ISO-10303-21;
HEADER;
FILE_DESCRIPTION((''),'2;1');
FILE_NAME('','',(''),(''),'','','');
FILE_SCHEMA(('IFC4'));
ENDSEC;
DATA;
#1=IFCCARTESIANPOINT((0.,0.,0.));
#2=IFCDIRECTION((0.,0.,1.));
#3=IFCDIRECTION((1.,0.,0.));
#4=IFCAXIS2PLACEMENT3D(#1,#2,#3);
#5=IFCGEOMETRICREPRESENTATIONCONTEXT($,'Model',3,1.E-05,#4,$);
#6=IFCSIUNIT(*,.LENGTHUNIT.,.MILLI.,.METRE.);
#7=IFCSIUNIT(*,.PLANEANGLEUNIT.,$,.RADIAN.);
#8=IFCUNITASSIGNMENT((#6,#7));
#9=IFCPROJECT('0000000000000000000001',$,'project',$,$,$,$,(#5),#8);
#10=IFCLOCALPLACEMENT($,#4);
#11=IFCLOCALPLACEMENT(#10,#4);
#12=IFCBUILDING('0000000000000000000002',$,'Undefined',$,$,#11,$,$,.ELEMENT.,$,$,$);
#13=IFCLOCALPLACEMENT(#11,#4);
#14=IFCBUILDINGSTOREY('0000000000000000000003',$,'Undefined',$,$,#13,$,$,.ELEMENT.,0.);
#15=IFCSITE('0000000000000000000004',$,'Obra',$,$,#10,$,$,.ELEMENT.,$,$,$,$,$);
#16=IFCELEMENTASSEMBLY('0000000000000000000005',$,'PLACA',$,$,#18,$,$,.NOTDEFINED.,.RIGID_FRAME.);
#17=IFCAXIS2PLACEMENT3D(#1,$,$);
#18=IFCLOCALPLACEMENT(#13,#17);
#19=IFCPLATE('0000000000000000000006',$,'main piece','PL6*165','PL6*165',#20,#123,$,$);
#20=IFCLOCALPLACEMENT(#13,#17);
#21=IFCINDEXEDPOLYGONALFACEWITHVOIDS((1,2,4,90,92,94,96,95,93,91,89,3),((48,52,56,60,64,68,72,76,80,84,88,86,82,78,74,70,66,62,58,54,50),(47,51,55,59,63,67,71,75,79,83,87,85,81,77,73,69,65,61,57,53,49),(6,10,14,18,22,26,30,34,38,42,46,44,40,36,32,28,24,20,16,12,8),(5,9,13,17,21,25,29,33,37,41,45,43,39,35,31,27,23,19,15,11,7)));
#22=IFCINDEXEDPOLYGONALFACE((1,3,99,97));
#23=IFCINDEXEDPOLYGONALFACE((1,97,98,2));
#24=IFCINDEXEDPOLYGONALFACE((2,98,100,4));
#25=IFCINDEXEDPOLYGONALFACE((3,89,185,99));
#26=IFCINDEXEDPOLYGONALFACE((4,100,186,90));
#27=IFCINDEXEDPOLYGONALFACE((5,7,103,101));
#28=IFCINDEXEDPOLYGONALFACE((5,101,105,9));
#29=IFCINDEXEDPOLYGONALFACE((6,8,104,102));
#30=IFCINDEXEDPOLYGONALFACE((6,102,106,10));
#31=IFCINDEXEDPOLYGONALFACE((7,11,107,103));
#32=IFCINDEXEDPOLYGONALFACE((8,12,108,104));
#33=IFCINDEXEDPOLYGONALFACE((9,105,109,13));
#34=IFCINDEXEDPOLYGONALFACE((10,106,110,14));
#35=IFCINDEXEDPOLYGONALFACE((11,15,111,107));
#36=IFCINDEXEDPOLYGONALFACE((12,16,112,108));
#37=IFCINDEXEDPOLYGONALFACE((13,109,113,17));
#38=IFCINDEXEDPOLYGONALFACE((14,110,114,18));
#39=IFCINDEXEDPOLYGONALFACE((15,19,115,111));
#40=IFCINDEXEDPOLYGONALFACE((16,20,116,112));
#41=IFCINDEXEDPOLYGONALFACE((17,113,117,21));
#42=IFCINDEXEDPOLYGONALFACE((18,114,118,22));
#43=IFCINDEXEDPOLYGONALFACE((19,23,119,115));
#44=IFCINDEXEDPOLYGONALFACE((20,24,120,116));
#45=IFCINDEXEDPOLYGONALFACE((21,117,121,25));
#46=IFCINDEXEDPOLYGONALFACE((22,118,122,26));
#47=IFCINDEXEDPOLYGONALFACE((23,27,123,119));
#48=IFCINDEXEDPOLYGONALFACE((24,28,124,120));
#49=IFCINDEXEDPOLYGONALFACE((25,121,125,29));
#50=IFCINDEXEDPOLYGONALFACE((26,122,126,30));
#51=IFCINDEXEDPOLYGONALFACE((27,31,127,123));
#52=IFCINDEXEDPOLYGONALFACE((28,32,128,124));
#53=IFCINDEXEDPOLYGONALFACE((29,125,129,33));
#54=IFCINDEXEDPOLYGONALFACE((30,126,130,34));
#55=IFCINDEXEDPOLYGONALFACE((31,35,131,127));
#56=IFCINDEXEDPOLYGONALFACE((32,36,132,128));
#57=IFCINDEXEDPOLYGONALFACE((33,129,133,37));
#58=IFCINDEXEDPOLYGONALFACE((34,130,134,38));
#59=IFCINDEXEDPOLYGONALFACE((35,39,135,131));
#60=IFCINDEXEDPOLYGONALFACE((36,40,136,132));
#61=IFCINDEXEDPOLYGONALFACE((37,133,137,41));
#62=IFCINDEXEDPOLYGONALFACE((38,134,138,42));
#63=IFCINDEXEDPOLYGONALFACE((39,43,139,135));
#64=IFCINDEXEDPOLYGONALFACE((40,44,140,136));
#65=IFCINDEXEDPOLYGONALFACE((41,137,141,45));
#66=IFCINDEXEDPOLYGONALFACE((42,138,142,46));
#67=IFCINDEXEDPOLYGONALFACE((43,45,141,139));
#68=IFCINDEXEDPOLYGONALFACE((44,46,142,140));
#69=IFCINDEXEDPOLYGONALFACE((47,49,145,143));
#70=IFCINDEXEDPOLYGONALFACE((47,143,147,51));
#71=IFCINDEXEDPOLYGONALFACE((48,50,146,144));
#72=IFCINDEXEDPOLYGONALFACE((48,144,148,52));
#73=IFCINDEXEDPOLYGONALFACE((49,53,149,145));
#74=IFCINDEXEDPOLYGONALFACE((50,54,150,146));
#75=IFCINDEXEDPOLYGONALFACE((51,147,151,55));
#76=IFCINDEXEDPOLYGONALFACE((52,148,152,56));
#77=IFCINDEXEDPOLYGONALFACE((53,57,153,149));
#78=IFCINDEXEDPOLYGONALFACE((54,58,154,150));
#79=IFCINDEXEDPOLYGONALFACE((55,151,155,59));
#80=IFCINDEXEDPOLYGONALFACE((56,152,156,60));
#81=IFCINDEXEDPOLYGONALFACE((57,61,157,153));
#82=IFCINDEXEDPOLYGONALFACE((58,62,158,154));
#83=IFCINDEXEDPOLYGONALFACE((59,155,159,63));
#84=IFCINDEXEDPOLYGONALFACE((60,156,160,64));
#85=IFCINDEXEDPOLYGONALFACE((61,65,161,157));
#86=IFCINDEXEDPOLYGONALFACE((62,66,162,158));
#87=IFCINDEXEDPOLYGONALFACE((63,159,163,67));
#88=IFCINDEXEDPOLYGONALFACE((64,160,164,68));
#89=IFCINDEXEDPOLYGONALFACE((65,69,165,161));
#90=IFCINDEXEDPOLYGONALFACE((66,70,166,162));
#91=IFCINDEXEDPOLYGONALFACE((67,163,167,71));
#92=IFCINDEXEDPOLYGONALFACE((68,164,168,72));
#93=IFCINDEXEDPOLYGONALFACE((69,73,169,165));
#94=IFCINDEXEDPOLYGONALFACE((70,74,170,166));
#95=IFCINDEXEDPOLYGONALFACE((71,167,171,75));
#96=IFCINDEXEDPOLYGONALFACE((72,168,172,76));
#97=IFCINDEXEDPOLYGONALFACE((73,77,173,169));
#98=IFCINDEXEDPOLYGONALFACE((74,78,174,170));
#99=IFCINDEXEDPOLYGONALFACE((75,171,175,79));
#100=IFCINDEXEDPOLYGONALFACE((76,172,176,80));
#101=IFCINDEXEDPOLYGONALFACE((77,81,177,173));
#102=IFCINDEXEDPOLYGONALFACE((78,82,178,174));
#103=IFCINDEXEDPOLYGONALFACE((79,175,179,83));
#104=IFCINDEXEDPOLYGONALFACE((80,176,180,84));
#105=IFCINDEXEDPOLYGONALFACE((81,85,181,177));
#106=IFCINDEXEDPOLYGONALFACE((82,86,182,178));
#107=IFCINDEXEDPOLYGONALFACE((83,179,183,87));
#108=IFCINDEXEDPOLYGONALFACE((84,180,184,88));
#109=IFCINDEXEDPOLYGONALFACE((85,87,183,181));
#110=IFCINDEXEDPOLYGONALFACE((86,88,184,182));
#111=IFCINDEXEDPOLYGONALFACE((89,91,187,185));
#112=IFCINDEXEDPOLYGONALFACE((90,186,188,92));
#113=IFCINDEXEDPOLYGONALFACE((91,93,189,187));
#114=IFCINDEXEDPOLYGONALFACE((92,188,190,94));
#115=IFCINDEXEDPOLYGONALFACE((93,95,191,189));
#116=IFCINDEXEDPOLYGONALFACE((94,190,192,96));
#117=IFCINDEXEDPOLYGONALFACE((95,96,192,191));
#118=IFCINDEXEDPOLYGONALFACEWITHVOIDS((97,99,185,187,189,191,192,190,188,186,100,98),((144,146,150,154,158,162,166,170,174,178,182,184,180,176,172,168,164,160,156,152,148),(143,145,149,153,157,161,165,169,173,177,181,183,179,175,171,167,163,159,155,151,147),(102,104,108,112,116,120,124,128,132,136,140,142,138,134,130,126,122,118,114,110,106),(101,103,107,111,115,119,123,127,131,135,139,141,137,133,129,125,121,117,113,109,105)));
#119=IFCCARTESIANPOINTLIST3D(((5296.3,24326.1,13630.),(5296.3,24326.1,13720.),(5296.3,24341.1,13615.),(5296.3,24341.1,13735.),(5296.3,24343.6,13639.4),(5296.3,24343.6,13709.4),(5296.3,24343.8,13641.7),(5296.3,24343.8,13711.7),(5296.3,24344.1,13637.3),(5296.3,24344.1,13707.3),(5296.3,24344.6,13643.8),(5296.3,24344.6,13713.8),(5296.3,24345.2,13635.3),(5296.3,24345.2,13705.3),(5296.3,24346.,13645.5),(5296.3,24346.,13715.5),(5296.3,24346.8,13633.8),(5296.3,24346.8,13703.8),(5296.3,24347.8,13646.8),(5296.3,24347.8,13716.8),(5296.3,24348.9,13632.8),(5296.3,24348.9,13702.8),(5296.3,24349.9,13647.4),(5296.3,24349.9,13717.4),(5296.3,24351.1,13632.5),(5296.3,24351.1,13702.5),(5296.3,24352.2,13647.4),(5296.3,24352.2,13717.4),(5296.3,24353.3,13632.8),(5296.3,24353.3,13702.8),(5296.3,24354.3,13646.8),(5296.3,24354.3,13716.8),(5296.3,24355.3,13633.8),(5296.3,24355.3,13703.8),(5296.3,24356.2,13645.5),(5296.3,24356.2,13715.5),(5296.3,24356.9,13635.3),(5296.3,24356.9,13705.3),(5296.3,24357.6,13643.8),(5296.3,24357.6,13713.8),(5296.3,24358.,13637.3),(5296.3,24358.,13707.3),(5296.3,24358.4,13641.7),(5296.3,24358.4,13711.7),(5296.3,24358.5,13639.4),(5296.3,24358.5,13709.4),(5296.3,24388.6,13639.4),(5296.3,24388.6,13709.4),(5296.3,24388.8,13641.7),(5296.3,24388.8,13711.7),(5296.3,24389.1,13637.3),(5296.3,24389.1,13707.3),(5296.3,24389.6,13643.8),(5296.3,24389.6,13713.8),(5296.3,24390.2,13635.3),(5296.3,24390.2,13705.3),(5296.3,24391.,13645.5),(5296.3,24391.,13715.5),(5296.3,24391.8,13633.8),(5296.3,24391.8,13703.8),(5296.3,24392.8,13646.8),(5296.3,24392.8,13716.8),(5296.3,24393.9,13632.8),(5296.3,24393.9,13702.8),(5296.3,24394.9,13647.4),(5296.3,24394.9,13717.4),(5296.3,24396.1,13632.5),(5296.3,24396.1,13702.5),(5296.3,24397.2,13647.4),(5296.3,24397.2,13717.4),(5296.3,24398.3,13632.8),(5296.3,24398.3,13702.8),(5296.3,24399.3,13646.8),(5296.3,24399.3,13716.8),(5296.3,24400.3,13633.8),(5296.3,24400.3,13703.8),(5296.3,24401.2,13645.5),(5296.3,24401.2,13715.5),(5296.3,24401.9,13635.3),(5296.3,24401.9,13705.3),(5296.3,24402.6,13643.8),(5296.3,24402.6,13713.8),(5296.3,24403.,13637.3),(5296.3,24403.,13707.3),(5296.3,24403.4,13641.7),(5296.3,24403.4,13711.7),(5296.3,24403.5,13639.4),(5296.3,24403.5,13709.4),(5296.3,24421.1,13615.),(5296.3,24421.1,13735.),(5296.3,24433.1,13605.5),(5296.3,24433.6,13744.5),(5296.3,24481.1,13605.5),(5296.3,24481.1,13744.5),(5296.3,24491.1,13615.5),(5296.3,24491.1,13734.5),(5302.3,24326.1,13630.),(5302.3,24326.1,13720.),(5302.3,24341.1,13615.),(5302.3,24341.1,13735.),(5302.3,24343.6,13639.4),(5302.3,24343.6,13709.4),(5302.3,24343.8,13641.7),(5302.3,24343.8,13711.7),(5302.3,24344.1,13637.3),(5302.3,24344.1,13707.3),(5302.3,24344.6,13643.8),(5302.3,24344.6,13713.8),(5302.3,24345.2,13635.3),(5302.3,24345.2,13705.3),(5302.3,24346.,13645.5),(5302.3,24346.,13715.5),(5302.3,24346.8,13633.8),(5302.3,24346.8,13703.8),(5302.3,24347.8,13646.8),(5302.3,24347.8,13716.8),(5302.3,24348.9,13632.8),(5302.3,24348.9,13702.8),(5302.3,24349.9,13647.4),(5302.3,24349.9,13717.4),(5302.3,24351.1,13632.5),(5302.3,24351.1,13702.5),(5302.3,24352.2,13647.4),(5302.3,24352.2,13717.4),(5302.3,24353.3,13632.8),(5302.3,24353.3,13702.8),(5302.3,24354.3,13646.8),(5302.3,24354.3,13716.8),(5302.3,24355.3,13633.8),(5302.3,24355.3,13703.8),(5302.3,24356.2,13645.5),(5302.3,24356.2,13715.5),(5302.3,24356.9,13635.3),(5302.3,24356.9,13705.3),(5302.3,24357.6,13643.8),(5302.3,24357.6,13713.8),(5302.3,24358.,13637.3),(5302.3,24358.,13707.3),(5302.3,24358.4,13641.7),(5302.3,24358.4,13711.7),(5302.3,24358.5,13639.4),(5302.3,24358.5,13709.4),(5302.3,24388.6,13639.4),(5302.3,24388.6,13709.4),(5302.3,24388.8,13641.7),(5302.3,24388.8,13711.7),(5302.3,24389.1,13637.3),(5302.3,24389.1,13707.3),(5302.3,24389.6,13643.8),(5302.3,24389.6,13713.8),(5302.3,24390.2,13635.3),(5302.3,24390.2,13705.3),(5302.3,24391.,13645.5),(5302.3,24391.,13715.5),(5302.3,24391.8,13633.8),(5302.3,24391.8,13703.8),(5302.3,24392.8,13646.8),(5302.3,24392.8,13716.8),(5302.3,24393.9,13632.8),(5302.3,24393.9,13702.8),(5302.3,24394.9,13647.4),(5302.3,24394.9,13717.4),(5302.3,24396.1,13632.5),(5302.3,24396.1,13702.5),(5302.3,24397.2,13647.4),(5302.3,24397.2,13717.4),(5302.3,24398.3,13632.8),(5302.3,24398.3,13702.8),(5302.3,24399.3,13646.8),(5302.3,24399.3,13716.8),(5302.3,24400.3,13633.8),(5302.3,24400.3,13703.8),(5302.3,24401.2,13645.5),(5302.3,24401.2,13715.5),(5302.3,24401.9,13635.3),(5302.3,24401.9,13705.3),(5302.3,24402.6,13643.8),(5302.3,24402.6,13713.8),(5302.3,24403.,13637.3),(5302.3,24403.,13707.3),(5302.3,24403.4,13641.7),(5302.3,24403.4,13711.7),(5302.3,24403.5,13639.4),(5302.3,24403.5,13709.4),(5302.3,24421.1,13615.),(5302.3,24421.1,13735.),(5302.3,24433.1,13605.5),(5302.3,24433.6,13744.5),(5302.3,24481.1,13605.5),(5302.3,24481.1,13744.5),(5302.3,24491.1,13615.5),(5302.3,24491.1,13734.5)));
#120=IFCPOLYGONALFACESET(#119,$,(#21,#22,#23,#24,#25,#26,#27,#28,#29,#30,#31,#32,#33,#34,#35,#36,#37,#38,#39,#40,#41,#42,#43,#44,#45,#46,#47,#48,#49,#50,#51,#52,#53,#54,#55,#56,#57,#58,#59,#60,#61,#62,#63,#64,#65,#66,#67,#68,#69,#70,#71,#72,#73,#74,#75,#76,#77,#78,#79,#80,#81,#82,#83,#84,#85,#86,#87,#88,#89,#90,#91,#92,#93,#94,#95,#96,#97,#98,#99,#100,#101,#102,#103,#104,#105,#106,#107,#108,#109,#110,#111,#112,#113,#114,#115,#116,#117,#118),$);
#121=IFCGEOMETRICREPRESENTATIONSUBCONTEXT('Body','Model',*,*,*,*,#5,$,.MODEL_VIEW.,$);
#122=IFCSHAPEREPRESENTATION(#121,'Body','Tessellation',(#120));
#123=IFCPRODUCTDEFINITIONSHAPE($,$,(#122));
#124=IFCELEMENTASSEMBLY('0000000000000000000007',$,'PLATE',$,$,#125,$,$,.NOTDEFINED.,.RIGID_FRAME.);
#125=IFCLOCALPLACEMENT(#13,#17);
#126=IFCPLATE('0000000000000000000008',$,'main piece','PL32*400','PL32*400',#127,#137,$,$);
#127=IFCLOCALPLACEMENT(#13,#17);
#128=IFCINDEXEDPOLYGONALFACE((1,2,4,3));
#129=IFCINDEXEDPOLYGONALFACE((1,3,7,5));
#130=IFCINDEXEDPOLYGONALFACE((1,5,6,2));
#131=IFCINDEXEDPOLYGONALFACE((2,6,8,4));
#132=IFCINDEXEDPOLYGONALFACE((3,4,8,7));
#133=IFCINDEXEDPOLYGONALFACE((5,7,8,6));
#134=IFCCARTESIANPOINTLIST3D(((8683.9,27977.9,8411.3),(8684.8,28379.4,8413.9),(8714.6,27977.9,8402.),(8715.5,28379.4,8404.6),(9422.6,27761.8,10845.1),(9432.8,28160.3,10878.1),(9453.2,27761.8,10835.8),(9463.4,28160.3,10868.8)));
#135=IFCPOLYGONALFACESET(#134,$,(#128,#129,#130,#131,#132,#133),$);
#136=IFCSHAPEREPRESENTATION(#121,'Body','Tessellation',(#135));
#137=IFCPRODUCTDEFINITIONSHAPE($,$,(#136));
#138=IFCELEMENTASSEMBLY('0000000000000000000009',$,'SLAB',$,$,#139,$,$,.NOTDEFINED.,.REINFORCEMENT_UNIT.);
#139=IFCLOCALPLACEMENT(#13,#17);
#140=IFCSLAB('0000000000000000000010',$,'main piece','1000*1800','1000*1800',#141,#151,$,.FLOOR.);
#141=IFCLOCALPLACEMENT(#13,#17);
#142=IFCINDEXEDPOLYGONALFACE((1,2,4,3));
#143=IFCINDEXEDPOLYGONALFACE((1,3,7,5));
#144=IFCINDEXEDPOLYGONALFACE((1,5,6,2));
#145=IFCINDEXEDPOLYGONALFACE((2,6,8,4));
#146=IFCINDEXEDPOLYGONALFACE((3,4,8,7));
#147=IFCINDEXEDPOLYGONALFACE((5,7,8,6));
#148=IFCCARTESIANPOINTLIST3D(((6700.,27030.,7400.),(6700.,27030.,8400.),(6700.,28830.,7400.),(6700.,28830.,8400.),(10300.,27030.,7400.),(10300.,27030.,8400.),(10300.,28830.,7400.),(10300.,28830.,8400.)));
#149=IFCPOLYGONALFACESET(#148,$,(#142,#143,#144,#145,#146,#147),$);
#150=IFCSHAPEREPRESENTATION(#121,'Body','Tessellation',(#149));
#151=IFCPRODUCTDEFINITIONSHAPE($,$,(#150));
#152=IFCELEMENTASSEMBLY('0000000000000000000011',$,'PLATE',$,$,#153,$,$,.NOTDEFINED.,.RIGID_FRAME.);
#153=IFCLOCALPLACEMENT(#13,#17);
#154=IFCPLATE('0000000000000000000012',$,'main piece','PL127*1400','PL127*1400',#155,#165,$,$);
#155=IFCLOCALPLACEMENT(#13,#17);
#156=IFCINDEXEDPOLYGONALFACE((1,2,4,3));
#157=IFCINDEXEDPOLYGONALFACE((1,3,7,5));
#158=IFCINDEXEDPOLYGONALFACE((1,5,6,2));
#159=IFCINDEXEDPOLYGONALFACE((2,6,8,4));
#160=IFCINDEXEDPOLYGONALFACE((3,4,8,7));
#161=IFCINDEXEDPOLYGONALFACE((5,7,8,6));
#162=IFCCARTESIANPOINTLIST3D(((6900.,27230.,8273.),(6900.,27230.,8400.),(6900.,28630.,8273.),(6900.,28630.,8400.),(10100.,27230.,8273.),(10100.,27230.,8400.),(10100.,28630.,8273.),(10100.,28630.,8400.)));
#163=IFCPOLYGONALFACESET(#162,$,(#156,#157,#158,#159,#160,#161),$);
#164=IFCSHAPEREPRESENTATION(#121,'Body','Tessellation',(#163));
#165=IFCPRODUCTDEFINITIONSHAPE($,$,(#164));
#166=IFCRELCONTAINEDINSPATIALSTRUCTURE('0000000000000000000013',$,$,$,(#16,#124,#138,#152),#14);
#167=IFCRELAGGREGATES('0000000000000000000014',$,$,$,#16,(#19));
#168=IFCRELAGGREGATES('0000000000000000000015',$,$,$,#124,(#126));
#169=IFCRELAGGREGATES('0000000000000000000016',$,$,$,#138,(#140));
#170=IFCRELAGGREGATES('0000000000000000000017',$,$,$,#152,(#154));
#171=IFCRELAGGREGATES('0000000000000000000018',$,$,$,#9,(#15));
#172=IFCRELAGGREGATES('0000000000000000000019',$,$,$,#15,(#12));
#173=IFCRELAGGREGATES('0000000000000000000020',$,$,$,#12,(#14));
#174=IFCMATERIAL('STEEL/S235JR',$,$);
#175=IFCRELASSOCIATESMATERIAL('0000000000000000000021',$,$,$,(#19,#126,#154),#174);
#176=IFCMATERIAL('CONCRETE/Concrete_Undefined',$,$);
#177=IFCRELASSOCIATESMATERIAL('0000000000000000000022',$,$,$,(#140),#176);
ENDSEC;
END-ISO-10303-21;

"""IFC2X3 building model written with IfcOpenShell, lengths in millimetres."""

from ifc_helpers import new_model, si_unit, frame, origin_with_axes, origin_2d_with_axis, place, context, subcontext, project, spatial, polyline, circle, outline, extrude, source, transform, mapped, material, element, aggregate, save


model = new_model("IFC2X3")

# Units and contexts
model_context = context("Model", 3, precision=1e-05, world=origin_with_axes())
body_context = subcontext(model_context, "Body", "Model", "MODEL_VIEW")
ifc_project = project(units=[si_unit("LENGTHUNIT", "METRE", prefix="MILLI"), si_unit("PLANEANGLEUNIT", "RADIAN")], contexts=[model_context])

# Site, building, storey
site_placement = place(None, origin_with_axes())
site = spatial("IfcSite", under=ifc_project, at=site_placement, Name="Obra", CompositionType="ELEMENT")
building_placement = place(site_placement, origin_with_axes())
building = spatial("IfcBuilding", under=site, at=building_placement, Name="Undefined", CompositionType="ELEMENT")
storey_placement = place(building_placement, origin_with_axes())
storey = spatial("IfcBuildingStorey", under=building, at=storey_placement, Name="Undefined", CompositionType="ELEMENT", Elevation=0.0)

# Shared definitions
ifc_material_1 = material(Name="STEEL/S235JR")

# Element assembly, plate, opening
assembly_1_placement = place(storey_placement, origin_with_axes())
assembly_1 = element("IfcElementAssembly", 1, at=assembly_1_placement, inside=storey, Name="PLACA", AssemblyPlace="NOTDEFINED", PredefinedType="RIGID_FRAME")
plate_1_placement = place(assembly_1_placement, frame((5299.3, 24491.1, 13615.5), z_axis=(-1.0, 0.0, 0.0), x_axis=(0.000001, -0.707107, -0.707107)))
plate_1 = element("IfcPlate", 2, at=plate_1_placement, material=ifc_material_1, Name="main piece", Description="PL6*165", ObjectType="PL6*165", context=body_context, shape_type="SweptSolid", body=[
    extrude(outline(polyline([(0.0, 0.0), (14.1, 0.0), (48.1, 33.9), (49.9, 49.1), (106.4, 105.7), (106.4, 126.9), (42.8, 190.6), (21.6, 190.6), (-35.0, 134.0), (-50.6, 131.9), (-84.1, 98.3), (-84.1, 84.1), (0.0, 0.0)])), frame((0.0, 0.0, -3.0), z_axis=(0.0, 0.0, 1.0), x_axis=(1.0, 0.0, 0.0)), (0.0, 0.0, 1.0), 6.0),
])
shared_shape_1 = source(origin_with_axes(), body_context, "Body", "SweptSolid", [
    extrude(circle(Radius=7.5, at=origin_2d_with_axis()), frame((0.0, -0.1, 0.0), z_axis=(0.0, 1.0, 0.0), x_axis=(1.0, 0.0, 0.0)), (0.0, 0.0, 1.0), 6.2),
])
opening_1_placement = place(assembly_1_placement, frame((5296.3, 24373.6, 13710.0), z_axis=(0.0, -1.0, 0.0), x_axis=(0.0, 0.0, -1.0)))
element("IfcOpeningElement", 3, at=opening_1_placement, cuts=plate_1, ObjectType="Opening", context=body_context, shape_type="MappedRepresentation", body=[
    mapped(shared_shape_1, transform((0.0, 0.0, -22.5))),
    mapped(shared_shape_1, transform((70.0, 0.0, -22.5))),
    mapped(shared_shape_1, transform((0.0, 0.0, 22.5))),
    mapped(shared_shape_1, transform((70.0, 0.0, 22.5))),
])
aggregate(assembly_1, [plate_1])

# Element assembly, plate
assembly_2_placement = place(storey_placement, origin_with_axes())
assembly_2 = element("IfcElementAssembly", 4, at=assembly_2_placement, inside=storey, Name="PLATE", AssemblyPlace="NOTDEFINED", PredefinedType="RIGID_FRAME")
plate_2_placement = place(assembly_2_placement, frame((9437.9, 27761.8, 10840.4), z_axis=(-0.95689, 0.000272, 0.290451), x_axis=(0.025372, 0.996255, 0.082653)))
plate_2 = element("IfcPlate", 5, at=plate_2_placement, material=ifc_material_1, Name="main piece", Description="PL32*400", ObjectType="PL32*400", context=body_context, shape_type="SweptSolid", body=[
    extrude(outline(polyline([(0.0, 0.0), (400.0, 0.0), (395.7, 2584.5), (-4.6, 2552.6), (0.0, 0.0)])), frame((0.0, 0.0, -16.0), z_axis=(0.0, 0.0, 1.0), x_axis=(1.0, 0.0, 0.0)), (0.0, 0.0, 1.0), 32.0),
])
aggregate(assembly_2, [plate_2])

# Element assembly, slab
assembly_3_placement = place(storey_placement, origin_with_axes())
assembly_3 = element("IfcElementAssembly", 6, at=assembly_3_placement, inside=storey, Name="SLAB", AssemblyPlace="NOTDEFINED", PredefinedType="REINFORCEMENT_UNIT")
ifc_material_2 = material(Name="CONCRETE/Concrete_Undefined")
slab_placement = place(assembly_3_placement, frame((6700.0, 27030.0, 7900.0), z_axis=(0.0, 0.0, -1.0), x_axis=(0.0, 1.0, 0.0)))
slab = element("IfcSlab", 7, at=slab_placement, material=ifc_material_2, Name="main piece", Description="1000*1800", ObjectType="1000*1800", PredefinedType="FLOOR", context=body_context, shape_type="SweptSolid", body=[
    extrude(outline(polyline([(0.0, 0.0), (1800.0, 0.0), (1800.0, 3600.0), (0.0, 3600.0), (0.0, 0.0)])), frame((0.0, 0.0, -500.0), z_axis=(0.0, 0.0, 1.0), x_axis=(1.0, 0.0, 0.0)), (0.0, 0.0, 1.0), 1000.0),
])
aggregate(assembly_3, [slab])

# Element assembly, plate
assembly_4_placement = place(storey_placement, origin_with_axes())
assembly_4 = element("IfcElementAssembly", 8, at=assembly_4_placement, inside=storey, Name="PLATE", AssemblyPlace="NOTDEFINED", PredefinedType="RIGID_FRAME")
plate_3_placement = place(assembly_4_placement, frame((6900.0, 27230.0, 8336.5), z_axis=(0.0, 0.0, 1.0), x_axis=(1.0, 0.0, 0.0)))
plate_3 = element("IfcPlate", 9, at=plate_3_placement, material=ifc_material_1, Name="main piece", Description="PL127*1400", ObjectType="PL127*1400", context=body_context, shape_type="SweptSolid", body=[
    extrude(outline(polyline([(0.0, 0.0), (3200.0, 0.0), (3200.0, 1400.0), (0.0, 1400.0), (0.0, 0.0)])), frame((0.0, 0.0, -63.5), z_axis=(0.0, 0.0, 1.0), x_axis=(1.0, 0.0, 0.0)), (0.0, 0.0, 1.0), 127.0),
])

aggregate(assembly_4, [plate_3])

save(model, "model.ifc")
